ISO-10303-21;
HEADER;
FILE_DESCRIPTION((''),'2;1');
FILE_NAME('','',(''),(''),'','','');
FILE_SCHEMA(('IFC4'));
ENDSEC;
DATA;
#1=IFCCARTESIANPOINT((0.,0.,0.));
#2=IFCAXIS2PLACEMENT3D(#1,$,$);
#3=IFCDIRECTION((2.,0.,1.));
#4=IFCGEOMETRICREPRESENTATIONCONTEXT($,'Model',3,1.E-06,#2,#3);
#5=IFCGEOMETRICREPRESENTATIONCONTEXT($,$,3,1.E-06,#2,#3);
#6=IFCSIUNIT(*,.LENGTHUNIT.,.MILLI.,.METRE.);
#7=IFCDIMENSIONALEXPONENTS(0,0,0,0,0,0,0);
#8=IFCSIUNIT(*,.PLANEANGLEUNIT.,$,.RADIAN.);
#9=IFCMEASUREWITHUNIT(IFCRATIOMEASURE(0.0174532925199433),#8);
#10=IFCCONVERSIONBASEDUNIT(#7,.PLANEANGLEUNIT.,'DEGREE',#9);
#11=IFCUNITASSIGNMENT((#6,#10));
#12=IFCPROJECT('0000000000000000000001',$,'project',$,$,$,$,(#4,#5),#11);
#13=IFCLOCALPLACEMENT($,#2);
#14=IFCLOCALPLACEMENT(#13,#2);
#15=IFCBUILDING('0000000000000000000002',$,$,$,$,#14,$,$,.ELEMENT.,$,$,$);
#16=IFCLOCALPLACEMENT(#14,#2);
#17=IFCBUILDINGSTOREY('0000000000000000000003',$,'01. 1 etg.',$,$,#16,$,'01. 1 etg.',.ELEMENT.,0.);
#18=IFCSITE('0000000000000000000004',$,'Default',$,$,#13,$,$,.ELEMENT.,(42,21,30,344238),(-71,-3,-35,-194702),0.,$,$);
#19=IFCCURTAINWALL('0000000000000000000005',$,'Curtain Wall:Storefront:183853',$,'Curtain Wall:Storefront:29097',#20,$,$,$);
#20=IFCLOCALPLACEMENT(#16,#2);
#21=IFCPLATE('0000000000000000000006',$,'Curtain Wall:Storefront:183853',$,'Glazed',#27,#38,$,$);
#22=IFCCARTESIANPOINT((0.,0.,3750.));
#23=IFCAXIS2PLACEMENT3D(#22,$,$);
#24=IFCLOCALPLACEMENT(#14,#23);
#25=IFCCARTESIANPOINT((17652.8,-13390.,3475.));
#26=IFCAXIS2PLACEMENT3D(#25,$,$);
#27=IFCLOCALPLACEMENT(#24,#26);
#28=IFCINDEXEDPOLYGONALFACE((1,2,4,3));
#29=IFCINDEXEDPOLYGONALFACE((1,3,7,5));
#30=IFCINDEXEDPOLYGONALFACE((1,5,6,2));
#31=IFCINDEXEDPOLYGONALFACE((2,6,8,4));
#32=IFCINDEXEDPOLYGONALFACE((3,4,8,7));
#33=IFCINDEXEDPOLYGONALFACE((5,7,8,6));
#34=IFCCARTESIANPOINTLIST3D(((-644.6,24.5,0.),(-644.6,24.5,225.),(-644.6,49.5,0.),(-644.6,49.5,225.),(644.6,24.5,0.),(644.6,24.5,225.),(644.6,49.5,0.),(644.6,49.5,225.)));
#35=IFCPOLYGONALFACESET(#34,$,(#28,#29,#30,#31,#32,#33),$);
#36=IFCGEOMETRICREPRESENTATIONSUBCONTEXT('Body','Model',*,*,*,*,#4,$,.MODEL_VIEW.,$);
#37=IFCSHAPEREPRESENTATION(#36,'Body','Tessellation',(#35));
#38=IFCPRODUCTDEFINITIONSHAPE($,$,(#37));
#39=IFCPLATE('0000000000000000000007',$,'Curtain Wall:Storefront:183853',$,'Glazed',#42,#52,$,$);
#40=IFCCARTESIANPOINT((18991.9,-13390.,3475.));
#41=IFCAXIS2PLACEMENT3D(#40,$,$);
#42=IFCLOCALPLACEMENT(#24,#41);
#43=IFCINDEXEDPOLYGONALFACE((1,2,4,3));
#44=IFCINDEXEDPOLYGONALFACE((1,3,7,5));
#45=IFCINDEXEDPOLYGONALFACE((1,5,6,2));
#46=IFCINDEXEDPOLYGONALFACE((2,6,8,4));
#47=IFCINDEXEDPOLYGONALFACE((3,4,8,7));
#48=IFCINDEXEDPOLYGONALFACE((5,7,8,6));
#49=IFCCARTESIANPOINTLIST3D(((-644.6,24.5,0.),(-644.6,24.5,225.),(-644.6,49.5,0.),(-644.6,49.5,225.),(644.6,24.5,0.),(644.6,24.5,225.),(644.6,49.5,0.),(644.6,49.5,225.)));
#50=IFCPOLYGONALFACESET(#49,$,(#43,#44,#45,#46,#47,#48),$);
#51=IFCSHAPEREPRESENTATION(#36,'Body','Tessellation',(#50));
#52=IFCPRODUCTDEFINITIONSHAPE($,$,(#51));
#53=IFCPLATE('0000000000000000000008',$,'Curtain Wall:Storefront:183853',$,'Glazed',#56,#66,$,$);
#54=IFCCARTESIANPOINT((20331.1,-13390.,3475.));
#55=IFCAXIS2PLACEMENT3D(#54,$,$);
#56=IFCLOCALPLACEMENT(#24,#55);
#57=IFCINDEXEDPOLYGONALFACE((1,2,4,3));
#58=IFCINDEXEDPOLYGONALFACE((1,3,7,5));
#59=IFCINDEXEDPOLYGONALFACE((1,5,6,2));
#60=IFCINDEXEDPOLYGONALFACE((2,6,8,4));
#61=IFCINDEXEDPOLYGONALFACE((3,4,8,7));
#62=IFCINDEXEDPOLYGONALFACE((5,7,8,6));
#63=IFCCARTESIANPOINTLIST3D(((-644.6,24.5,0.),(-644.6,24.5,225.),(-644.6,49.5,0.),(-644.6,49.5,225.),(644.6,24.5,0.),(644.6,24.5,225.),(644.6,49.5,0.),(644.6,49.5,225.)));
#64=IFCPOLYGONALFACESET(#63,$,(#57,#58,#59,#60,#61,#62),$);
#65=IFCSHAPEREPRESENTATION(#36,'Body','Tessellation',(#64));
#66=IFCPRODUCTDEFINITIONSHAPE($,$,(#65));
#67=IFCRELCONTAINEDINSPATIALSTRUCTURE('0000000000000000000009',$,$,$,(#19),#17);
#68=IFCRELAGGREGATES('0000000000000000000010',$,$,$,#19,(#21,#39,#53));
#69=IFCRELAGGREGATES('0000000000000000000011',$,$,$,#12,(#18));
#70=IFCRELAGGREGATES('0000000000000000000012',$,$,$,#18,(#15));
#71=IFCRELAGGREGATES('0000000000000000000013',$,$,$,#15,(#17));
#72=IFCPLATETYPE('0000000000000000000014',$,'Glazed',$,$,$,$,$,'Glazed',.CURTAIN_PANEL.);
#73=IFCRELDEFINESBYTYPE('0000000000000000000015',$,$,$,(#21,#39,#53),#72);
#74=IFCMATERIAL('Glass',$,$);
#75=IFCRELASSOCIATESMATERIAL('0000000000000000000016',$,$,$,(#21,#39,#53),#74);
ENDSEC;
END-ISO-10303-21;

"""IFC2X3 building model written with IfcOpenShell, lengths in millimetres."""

from ifc_helpers import new_model, entity, si_unit, converted_unit, direction, frame, origin, origin_2d_with_axis, place, context, subcontext, project, spatial, rectangle, extrude, source, transform, mapped, material, type_object, type_shapes, element, aggregate, save


model = new_model("IFC2X3")

# Units and contexts
model_context = context("Model", 3, precision=1e-06, world=origin(), true_north=direction((2.0, 0.0, 1.0)))
context_of_model = context(None, 3, precision=1e-06, world=origin(), true_north=direction((2.0, 0.0, 1.0)))
body_context = subcontext(model_context, "Body", "Model", "MODEL_VIEW")
ifc_project = project(units=[si_unit("LENGTHUNIT", "METRE", prefix="MILLI"), converted_unit("PLANEANGLEUNIT", "DEGREE", entity("IfcRatioMeasure", 0.0174532925199433), si_unit("PLANEANGLEUNIT", "RADIAN"), dimensions=[0, 0, 0, 0, 0, 0, 0])], contexts=[model_context, context_of_model])

# Site, building, storey
site_placement = place(None, origin())
site = spatial("IfcSite", under=ifc_project, at=site_placement, Name="Default", CompositionType="ELEMENT", RefLatitude=(42, 21, 30, 344238), RefLongitude=(-71, -3, -35, -194702), RefElevation=0.0)
building_placement = place(site_placement, origin())
building = spatial("IfcBuilding", under=site, at=building_placement, CompositionType="ELEMENT")
storey_placement = place(building_placement, origin())
storey = spatial("IfcBuildingStorey", under=building, at=storey_placement, Name="01. 1 etg.", LongName="01. 1 etg.", CompositionType="ELEMENT", Elevation=0.0)

# Curtain wall, plates
curtain_wall_placement = place(storey_placement, origin())
curtain_wall = element("IfcCurtainWall", 1, at=curtain_wall_placement, inside=storey, Name="Curtain Wall:Storefront:183853", ObjectType="Curtain Wall:Storefront:29097")
ifc_material_1 = material(Name="Glass")
placement = place(building_placement, frame((0.0, 0.0, 3750.0)))
plate_type_1 = type_object("IfcPlateType", Name="Glazed", ElementType="Glazed", PredefinedType="CURTAIN_PANEL")
shared_shape_1 = source(origin(), body_context, "Body", "SweptSolid", [
    extrude(rectangle(XDim=25.0, YDim=1289.2, at=origin_2d_with_axis()), frame((0.0, 37.0, 0.0), z_axis=(0.0, 0.0, 1.0), x_axis=(0.0, 1.0, 0.0)), (0.0, 0.0, 1.0), 225.0),
])
type_shapes(plate_type_1, [shared_shape_1])
plate_1_placement = place(placement, frame((17652.8, -13390.0, 3475.0)))
plate_1 = element("IfcPlate", 2, at=plate_1_placement, type_object=plate_type_1, material=ifc_material_1, Name="Curtain Wall:Storefront:183853", ObjectType="Glazed", context=body_context, shape_type="MappedRepresentation", body=[
    mapped(shared_shape_1, transform((0.0, 0.0, 0.0), scale=1.0)),
])
plate_2_placement = place(placement, frame((18991.9, -13390.0, 3475.0)))
plate_2 = element("IfcPlate", 3, at=plate_2_placement, type_object=plate_type_1, material=ifc_material_1, Name="Curtain Wall:Storefront:183853", ObjectType="Glazed", context=body_context, shape_type="MappedRepresentation", body=[
    mapped(shared_shape_1, transform((0.0, 0.0, 0.0), scale=1.0)),
])
plate_3_placement = place(placement, frame((20331.1, -13390.0, 3475.0)))
plate_3 = element("IfcPlate", 4, at=plate_3_placement, type_object=plate_type_1, material=ifc_material_1, Name="Curtain Wall:Storefront:183853", ObjectType="Glazed", context=body_context, shape_type="MappedRepresentation", body=[
    mapped(shared_shape_1, transform((0.0, 0.0, 0.0), scale=1.0)),
])

aggregate(curtain_wall, [plate_1, plate_2, plate_3])

save(model, "model.ifc")
